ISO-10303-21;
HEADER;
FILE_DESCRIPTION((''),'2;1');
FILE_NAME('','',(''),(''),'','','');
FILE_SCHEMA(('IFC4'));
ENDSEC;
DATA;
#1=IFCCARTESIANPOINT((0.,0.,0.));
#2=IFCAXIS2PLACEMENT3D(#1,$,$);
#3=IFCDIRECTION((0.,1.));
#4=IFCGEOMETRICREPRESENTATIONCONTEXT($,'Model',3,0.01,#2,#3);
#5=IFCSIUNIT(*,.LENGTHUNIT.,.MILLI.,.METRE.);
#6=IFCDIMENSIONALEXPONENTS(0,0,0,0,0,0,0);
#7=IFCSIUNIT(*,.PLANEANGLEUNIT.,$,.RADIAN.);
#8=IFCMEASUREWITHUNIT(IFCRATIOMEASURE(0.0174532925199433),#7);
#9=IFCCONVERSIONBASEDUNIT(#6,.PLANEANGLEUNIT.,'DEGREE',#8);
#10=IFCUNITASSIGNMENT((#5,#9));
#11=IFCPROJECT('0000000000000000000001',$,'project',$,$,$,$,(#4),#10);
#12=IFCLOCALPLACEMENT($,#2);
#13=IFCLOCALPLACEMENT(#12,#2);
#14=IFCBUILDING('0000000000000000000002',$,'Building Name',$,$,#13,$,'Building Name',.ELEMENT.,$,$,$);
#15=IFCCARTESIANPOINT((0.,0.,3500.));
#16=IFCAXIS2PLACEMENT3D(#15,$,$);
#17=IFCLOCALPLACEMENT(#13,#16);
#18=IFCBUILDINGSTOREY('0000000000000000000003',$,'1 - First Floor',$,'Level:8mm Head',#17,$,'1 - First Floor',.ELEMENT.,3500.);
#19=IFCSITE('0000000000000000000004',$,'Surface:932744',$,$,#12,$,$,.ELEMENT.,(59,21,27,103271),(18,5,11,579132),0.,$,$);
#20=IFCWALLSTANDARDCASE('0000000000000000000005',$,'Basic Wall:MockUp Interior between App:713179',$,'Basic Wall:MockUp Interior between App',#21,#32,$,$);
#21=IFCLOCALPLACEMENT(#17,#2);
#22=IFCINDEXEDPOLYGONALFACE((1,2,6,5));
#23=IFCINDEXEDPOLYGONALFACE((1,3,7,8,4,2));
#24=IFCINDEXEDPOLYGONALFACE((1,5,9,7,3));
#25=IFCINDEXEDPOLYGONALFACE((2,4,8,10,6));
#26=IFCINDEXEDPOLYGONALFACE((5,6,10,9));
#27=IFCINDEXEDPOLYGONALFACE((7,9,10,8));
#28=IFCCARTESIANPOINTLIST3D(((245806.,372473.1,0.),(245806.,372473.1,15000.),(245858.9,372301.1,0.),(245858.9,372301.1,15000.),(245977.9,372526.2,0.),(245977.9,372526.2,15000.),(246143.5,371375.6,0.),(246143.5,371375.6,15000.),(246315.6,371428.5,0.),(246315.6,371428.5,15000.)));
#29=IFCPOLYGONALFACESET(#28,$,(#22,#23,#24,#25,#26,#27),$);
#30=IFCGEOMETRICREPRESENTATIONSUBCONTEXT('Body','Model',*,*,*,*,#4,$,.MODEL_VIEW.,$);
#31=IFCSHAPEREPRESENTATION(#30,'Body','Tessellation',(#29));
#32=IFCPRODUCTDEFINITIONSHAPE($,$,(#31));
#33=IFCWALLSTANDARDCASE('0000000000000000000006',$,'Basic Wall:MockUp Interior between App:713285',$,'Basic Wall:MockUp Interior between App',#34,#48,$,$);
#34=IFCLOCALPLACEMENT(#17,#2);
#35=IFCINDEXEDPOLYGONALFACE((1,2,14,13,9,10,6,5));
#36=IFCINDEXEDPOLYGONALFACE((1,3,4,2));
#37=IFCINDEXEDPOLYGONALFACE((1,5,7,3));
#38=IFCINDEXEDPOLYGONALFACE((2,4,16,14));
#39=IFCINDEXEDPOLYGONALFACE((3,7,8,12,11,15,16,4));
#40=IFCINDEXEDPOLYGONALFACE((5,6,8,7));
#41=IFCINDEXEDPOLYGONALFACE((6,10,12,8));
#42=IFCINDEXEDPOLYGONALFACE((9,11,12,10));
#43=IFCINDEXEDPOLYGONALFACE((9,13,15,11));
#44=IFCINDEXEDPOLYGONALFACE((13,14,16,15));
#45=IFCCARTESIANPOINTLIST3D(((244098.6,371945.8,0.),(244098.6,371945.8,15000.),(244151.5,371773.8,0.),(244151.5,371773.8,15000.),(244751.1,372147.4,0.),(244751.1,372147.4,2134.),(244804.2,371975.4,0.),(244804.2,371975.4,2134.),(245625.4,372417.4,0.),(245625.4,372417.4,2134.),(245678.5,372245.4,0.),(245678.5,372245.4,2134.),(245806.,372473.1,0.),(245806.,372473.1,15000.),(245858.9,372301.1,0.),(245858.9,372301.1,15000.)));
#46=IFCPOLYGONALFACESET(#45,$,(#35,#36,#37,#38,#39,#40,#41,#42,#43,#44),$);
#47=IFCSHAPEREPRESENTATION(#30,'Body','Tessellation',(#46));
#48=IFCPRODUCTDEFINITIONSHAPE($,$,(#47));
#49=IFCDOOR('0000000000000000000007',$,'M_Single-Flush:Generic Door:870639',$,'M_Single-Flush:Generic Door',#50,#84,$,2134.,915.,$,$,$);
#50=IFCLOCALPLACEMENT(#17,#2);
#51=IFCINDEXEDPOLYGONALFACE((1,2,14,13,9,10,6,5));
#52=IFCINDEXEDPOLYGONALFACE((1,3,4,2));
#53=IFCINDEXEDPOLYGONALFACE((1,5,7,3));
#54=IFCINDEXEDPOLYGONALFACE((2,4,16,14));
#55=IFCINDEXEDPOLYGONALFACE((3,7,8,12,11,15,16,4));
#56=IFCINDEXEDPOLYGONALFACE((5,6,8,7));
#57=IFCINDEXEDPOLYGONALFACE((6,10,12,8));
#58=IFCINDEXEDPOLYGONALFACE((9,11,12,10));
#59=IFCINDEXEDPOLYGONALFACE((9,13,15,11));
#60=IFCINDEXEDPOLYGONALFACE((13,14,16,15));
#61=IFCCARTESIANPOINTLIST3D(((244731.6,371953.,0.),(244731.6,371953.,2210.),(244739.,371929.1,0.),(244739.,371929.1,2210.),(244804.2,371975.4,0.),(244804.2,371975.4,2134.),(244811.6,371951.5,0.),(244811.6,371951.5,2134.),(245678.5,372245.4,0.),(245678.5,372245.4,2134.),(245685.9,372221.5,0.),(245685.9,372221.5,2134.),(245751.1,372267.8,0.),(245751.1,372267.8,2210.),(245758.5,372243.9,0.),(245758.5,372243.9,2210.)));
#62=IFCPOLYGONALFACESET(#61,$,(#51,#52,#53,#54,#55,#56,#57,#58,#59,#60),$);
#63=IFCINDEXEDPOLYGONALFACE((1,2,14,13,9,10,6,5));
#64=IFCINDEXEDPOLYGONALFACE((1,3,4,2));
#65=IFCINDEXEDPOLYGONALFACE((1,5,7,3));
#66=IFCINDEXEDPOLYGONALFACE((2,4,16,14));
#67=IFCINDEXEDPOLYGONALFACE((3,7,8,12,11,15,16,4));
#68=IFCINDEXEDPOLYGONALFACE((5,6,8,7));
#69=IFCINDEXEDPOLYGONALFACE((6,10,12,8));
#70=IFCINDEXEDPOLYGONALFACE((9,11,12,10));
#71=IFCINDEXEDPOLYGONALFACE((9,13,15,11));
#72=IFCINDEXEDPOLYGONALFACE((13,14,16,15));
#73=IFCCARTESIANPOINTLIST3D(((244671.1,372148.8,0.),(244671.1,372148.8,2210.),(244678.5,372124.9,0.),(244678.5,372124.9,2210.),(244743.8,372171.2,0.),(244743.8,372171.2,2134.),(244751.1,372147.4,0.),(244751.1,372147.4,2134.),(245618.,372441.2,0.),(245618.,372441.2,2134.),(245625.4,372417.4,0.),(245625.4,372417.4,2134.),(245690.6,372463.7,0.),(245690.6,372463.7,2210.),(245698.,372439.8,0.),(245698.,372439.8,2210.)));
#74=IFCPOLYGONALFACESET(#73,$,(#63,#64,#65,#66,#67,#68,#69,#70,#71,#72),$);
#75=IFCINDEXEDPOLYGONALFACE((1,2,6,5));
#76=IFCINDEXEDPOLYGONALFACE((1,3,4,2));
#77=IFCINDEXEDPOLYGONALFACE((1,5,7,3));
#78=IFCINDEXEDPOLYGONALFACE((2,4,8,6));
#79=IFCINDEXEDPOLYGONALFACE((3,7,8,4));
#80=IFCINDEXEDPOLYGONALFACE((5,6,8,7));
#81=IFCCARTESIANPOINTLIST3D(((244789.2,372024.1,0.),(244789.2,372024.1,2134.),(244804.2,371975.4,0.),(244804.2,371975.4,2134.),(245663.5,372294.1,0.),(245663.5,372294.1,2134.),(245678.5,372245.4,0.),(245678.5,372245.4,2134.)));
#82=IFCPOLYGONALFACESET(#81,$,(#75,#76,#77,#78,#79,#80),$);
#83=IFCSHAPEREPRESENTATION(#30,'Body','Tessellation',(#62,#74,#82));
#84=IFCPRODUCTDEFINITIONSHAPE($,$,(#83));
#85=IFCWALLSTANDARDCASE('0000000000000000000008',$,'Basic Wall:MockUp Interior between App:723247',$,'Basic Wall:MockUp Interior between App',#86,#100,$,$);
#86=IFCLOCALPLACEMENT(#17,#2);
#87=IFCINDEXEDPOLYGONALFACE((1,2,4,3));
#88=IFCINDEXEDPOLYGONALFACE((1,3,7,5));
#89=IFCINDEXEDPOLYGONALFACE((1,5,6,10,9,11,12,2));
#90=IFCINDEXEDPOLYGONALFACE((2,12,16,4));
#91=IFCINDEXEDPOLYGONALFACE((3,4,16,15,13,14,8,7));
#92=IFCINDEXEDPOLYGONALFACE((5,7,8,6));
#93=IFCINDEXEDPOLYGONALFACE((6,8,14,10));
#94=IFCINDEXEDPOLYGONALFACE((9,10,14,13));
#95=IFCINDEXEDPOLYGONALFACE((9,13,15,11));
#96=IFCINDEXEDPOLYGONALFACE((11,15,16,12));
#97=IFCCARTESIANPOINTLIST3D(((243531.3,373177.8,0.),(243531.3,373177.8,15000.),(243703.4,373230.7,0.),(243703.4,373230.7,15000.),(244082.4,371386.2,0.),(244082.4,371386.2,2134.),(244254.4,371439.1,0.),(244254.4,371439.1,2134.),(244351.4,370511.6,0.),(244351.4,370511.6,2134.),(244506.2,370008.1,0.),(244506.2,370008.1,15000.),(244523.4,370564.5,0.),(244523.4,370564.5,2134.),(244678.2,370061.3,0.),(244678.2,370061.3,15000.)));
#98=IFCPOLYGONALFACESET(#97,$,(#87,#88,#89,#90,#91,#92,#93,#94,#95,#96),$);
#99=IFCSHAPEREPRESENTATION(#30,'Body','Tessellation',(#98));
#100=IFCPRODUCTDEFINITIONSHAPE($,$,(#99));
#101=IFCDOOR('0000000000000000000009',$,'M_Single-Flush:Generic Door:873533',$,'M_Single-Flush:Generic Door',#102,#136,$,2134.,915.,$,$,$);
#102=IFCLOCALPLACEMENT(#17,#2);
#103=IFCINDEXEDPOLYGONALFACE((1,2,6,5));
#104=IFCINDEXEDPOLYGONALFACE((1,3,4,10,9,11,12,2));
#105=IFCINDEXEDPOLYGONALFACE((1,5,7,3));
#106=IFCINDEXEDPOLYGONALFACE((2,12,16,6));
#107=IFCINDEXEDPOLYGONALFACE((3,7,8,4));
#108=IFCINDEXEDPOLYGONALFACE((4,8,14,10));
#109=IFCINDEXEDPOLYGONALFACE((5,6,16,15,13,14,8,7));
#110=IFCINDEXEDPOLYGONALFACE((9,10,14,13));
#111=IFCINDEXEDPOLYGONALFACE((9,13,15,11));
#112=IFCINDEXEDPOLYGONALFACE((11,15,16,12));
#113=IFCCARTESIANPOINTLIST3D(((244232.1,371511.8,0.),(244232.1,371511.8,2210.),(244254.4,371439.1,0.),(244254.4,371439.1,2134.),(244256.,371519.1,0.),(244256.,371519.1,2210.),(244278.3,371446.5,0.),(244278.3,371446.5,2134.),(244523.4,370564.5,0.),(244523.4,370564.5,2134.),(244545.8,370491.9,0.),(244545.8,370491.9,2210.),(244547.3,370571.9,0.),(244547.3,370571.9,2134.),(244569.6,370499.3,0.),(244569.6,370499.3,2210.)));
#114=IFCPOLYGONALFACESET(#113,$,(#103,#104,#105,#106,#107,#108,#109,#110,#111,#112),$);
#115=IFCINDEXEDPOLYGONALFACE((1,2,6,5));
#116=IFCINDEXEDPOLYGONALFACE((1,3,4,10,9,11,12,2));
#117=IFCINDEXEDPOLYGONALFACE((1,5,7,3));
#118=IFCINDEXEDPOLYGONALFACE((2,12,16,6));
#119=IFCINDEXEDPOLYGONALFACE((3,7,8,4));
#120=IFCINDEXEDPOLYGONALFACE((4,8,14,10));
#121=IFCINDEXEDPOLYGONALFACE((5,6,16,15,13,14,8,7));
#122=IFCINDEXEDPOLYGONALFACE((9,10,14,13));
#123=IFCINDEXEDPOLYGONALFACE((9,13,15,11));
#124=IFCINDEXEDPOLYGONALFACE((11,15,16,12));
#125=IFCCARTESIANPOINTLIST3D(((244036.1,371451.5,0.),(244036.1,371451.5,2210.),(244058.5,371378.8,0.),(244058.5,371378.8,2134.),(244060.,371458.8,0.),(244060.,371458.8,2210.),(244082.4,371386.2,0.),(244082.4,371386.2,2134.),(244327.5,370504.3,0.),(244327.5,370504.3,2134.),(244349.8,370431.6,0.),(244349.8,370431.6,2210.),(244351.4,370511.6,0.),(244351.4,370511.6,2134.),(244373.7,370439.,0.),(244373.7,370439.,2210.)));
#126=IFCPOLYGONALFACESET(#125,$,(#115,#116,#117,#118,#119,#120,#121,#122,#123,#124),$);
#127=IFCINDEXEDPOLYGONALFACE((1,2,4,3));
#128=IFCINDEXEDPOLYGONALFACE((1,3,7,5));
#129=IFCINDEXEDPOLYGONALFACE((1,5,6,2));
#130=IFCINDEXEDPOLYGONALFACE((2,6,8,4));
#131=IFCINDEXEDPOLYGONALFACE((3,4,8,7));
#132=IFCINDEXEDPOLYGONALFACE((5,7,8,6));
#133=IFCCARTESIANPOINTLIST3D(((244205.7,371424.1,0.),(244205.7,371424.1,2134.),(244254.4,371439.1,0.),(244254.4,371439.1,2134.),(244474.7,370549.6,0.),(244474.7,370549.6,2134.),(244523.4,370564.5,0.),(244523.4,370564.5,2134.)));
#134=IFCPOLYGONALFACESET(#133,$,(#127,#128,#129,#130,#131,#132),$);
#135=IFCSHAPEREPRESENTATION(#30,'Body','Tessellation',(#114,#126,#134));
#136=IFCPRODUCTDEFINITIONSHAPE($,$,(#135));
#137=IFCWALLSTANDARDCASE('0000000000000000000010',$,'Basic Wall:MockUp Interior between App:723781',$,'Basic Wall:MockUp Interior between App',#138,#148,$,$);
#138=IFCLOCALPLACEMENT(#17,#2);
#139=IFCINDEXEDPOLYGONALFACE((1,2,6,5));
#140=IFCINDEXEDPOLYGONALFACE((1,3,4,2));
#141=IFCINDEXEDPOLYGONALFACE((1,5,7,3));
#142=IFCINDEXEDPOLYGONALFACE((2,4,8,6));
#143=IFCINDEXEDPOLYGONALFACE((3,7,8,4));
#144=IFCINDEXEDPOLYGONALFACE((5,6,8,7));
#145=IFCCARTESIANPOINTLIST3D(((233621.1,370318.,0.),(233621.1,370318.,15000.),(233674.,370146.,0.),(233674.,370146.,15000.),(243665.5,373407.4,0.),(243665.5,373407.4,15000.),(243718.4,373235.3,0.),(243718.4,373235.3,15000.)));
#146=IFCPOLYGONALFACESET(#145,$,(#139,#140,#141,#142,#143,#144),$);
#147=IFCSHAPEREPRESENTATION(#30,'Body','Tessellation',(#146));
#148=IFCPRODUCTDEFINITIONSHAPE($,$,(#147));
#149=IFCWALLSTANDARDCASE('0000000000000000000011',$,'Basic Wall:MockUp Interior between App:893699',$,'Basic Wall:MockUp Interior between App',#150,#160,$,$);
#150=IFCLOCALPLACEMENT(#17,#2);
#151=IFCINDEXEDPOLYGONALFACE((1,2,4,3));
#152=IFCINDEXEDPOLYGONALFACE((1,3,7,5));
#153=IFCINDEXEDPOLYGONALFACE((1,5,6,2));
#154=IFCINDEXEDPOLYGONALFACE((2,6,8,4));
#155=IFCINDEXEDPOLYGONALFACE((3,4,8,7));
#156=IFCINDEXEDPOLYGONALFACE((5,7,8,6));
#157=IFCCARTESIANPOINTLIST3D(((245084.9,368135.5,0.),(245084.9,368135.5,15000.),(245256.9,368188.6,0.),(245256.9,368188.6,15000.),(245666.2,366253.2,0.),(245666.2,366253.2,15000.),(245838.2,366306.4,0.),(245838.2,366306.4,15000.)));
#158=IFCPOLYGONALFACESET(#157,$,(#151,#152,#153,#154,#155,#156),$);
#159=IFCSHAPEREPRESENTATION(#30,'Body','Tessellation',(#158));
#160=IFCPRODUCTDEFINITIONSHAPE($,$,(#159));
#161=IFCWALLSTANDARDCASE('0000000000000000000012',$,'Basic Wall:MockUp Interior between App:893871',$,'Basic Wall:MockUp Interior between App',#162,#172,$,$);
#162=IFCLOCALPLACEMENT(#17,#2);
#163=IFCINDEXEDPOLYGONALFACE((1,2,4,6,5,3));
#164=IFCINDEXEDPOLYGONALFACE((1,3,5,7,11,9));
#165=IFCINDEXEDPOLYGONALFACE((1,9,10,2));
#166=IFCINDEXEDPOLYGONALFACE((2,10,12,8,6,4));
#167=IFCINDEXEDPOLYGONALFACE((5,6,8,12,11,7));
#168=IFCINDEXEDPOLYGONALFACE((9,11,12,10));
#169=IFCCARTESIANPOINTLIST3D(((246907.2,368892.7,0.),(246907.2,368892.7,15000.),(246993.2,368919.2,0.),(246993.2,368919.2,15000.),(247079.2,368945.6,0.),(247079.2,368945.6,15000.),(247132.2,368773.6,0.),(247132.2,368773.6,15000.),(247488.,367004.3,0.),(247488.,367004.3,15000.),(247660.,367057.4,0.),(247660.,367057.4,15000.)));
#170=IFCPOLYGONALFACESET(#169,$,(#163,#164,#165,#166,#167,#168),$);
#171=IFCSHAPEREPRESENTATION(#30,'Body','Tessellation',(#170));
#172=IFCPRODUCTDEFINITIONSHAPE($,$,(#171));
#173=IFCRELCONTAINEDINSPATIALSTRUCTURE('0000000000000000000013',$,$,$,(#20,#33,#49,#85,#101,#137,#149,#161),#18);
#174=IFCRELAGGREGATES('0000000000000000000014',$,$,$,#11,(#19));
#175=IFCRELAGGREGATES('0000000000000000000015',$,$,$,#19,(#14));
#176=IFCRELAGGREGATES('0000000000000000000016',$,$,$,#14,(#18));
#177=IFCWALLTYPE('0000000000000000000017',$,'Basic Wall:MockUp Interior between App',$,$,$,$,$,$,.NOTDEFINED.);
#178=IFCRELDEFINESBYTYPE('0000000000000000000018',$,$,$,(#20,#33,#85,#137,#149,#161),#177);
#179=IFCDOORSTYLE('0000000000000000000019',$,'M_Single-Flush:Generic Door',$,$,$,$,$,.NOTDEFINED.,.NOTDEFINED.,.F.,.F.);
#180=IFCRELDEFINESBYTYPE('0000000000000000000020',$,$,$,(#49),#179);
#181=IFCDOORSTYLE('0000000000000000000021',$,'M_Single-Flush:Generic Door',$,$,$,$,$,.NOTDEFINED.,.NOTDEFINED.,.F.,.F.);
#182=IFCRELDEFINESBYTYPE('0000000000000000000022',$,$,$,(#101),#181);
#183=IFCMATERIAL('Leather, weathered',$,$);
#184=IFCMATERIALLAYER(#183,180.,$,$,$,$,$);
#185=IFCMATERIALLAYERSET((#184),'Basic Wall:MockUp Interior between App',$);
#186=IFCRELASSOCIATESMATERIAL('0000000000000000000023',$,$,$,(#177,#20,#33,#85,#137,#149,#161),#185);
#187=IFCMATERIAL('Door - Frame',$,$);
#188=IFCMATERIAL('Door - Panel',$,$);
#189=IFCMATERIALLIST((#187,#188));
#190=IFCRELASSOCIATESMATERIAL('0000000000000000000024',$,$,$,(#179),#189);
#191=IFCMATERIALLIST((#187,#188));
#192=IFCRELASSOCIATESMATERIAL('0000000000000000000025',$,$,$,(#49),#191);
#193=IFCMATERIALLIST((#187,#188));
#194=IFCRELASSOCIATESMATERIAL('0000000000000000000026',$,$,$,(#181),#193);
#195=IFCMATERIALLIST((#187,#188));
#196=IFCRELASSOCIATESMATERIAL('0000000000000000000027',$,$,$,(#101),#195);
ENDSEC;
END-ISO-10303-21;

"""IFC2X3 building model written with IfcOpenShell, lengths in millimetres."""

from ifc_helpers import new_model, entity, si_unit, converted_unit, direction, frame, frame_2d, origin, place, context, subcontext, project, spatial, polyline, rectangle, outline, extrude, source, transform, mapped, material, material_list, layer, layer_set, layer_usage, type_object, type_shapes, element, fill, save


model = new_model("IFC2X3")

# Units and contexts
model_context = context("Model", 3, precision=0.01, world=origin(), true_north=direction((0.0, 1.0)))
body_context = subcontext(model_context, "Body", "Model", "MODEL_VIEW")
ifc_project = project(units=[si_unit("LENGTHUNIT", "METRE", prefix="MILLI"), converted_unit("PLANEANGLEUNIT", "DEGREE", entity("IfcRatioMeasure", 0.0174532925199433), si_unit("PLANEANGLEUNIT", "RADIAN"), dimensions=[0, 0, 0, 0, 0, 0, 0])], contexts=[model_context])

# Site, building, storey
site_placement = place(None, origin())
site = spatial("IfcSite", under=ifc_project, at=site_placement, Name="Surface:932744", CompositionType="ELEMENT", RefLatitude=(59, 21, 27, 103271), RefLongitude=(18, 5, 11, 579132), RefElevation=0.0)
building_placement = place(site_placement, origin())
building = spatial("IfcBuilding", under=site, at=building_placement, Name="Building Name", LongName="Building Name", CompositionType="ELEMENT")
storey_placement = place(building_placement, frame((0.0, 0.0, 3500.0)))
storey = spatial("IfcBuildingStorey", under=building, at=storey_placement, Name="1 - First Floor", ObjectType="Level:8mm Head", LongName="1 - First Floor", CompositionType="ELEMENT", Elevation=3500.0)

# Wall
ifc_material_1 = material(Name="Leather, weathered")
ifc_layer_1 = layer(ifc_material_1, 180.0)
ifc_layer_set_1 = layer_set([ifc_layer_1], Name="Basic Wall:MockUp Interior between App")
ifc_layer_usage_1 = layer_usage(ifc_layer_set_1, "AXIS2", "NEGATIVE", 90.0)
wall_type_1 = type_object("IfcWallType", Name="Basic Wall:MockUp Interior between App", PredefinedType="NOTDEFINED", material=ifc_layer_set_1)
wall_1_placement = place(storey_placement, frame((246229.5, 371402.1, 0.0), z_axis=(0.0, 0.0, 1.0), x_axis=(-0.29398, 0.955811, 0.0)))
element("IfcWallStandardCase", 1, at=wall_1_placement, inside=storey, type_object=wall_type_1, material=ifc_layer_usage_1, Name="Basic Wall:MockUp Interior between App:713179", ObjectType="Basic Wall:MockUp Interior between App", context=body_context, shape_type="SweptSolid", body=[
    extrude(outline(polyline([(1148.5, -90.0), (1148.3, 90.0), (968.3, 90.0), (0.0, 90.0), (0.0, -90.0), (1148.5, -90.0)])), origin(), (0.0, 0.0, 1.0), 15000.0),
])

# Walls, openings, doors
ifc_layer_usage_2 = layer_usage(ifc_layer_set_1, "AXIS2", "NEGATIVE", 90.0)
wall_2_placement = place(storey_placement, frame((245832.5, 372387.1, 0.0), z_axis=(0.0, 0.0, 1.0), x_axis=(-0.955473, -0.29508, 0.0)))
wall_2 = element("IfcWallStandardCase", 2, at=wall_2_placement, inside=storey, type_object=wall_type_1, material=ifc_layer_usage_2, Name="Basic Wall:MockUp Interior between App:713285", ObjectType="Basic Wall:MockUp Interior between App", context=body_context, shape_type="SweptSolid", body=[
    extrude(outline(polyline([(0.0, -90.0), (20.0, -90.0), (1787.0, -90.0), (1787.2, 90.0), (0.2, 90.0), (0.0, -90.0)])), origin(), (0.0, 0.0, 1.0), 15000.0),
])
opening_1_placement = place(wall_2_placement, frame((189.0, -90.0, 0.0)))
opening_1 = element("IfcOpeningElement", 3, at=opening_1_placement, cuts=wall_2, ObjectType="Opening", context=body_context, shape_type="SweptSolid", body=[
    extrude(rectangle(XDim=915.0, YDim=2134.0, at=frame_2d((1067.0, 457.5), x_axis=(0.0, -1.0))), frame((0.0, 0.0, 0.0), z_axis=(0.0, 1.0, 0.0), x_axis=(0.0, 0.0, 1.0)), (0.0, 0.0, 1.0), 180.0),
])
ifc_material_2 = material(Name="Door - Frame")
ifc_material_3 = material(Name="Door - Panel")
ifc_material_list_1 = material_list([ifc_material_2, ifc_material_3])
ifc_material_list_2 = material_list([ifc_material_2, ifc_material_3])
door_style_1 = type_object("IfcDoorStyle", Name="M_Single-Flush:Generic Door", ConstructionType="NOTDEFINED", OperationType="NOTDEFINED", ParameterTakesPrecedence=False, Sizeable=False, material=ifc_material_list_2)
shared_shape_1 = source(origin(), body_context, "Body", "SweptSolid", [
    extrude(outline(polyline([(-533.5, -1124.0), (533.5, -1124.0), (533.5, 1086.0), (457.5, 1086.0), (457.5, -1048.0), (-457.5, -1048.0), (-457.5, 1086.0), (-533.5, 1086.0), (-533.5, -1124.0)])), frame((457.5, 205.0, 1086.0), z_axis=(0.0, -1.0, 0.0), x_axis=(-1.0, 0.0, 0.0)), (0.0, 0.0, 1.0), 25.0),
    extrude(outline(polyline([(-1124.0, -533.5), (1086.0, -533.5), (1086.0, -457.5), (-1048.0, -457.5), (-1048.0, 457.5), (1086.0, 457.5), (1086.0, 533.5), (-1124.0, 533.5), (-1124.0, -533.5)])), frame((457.5, 0.0, 1086.0), z_axis=(0.0, -1.0, 0.0), x_axis=(0.0, 0.0, -1.0)), (0.0, 0.0, 1.0), 25.0),
    extrude(rectangle(XDim=915.0, YDim=51.0, at=frame_2d((0.0, 0.0), x_axis=(1.0, 0.0))), frame((457.5, 154.5, 0.0)), (0.0, 0.0, 1.0), 2134.0),
])
type_shapes(door_style_1, [shared_shape_1])
door_1_placement = place(opening_1_placement, origin())
door_1 = element("IfcDoor", 4, at=door_1_placement, inside=storey, type_object=door_style_1, material=ifc_material_list_1, Name="M_Single-Flush:Generic Door:870639", ObjectType="M_Single-Flush:Generic Door", OverallHeight=2134.0, OverallWidth=915.0, context=body_context, shape_type="MappedRepresentation", body=[
    mapped(shared_shape_1, transform((0.0, 0.0, 0.0), scale=1.0)),
])
fill(opening_1, door_1)
ifc_layer_usage_3 = layer_usage(ifc_layer_set_1, "AXIS2", "NEGATIVE", 90.0)
wall_3_placement = place(storey_placement, frame((243617.4, 373204.2, 0.0), z_axis=(0.0, 0.0, 1.0), x_axis=(0.29398, -0.955811, 0.0)))
wall_3 = element("IfcWallStandardCase", 5, at=wall_3_placement, inside=storey, type_object=wall_type_1, material=ifc_layer_usage_3, Name="Basic Wall:MockUp Interior between App:723247", ObjectType="Basic Wall:MockUp Interior between App", context=body_context, shape_type="SweptSolid", body=[
    extrude(outline(polyline([(0.0, -90.0), (3316.2, -90.0), (3316.0, 90.0), (1524.3, 90.0), (1344.3, 90.0), (0.0, 90.0), (0.0, -90.0)])), origin(), (0.0, 0.0, 1.0), 15000.0),
])
opening_2_placement = place(wall_3_placement, frame((1874.4, -90.0, 0.0)))
opening_2 = element("IfcOpeningElement", 6, at=opening_2_placement, cuts=wall_3, ObjectType="Opening", context=body_context, shape_type="SweptSolid", body=[
    extrude(rectangle(XDim=915.0, YDim=2134.0, at=frame_2d((1067.0, 457.5), x_axis=(0.0, 1.0))), frame((0.0, 0.0, 0.0), z_axis=(0.0, 1.0, 0.0), x_axis=(0.0, 0.0, 1.0)), (0.0, 0.0, 1.0), 180.0),
])
ifc_material_list_3 = material_list([ifc_material_2, ifc_material_3])
ifc_material_list_4 = material_list([ifc_material_2, ifc_material_3])
door_style_2 = type_object("IfcDoorStyle", Name="M_Single-Flush:Generic Door", ConstructionType="NOTDEFINED", OperationType="NOTDEFINED", ParameterTakesPrecedence=False, Sizeable=False, material=ifc_material_list_4)
shared_shape_2 = source(origin(), body_context, "Body", "SweptSolid", [
    extrude(outline(polyline([(-533.5, -1124.0), (533.5, -1124.0), (533.5, 1086.0), (457.5, 1086.0), (457.5, -1048.0), (-457.5, -1048.0), (-457.5, 1086.0), (-533.5, 1086.0), (-533.5, -1124.0)])), frame((457.5, 180.0, 1086.0), z_axis=(0.0, 1.0, 0.0), x_axis=(1.0, 0.0, 0.0)), (0.0, 0.0, 1.0), 25.0),
    extrude(outline(polyline([(-1124.0, -533.5), (1086.0, -533.5), (1086.0, -457.5), (-1048.0, -457.5), (-1048.0, 457.5), (1086.0, 457.5), (1086.0, 533.5), (-1124.0, 533.5), (-1124.0, -533.5)])), frame((457.5, -25.0, 1086.0), z_axis=(0.0, 1.0, 0.0), x_axis=(0.0, 0.0, -1.0)), (0.0, 0.0, 1.0), 25.0),
    extrude(rectangle(XDim=51.0, YDim=915.0, at=frame_2d((0.0, 0.0), x_axis=(1.0, 0.0))), frame((457.5, 154.5, 0.0), z_axis=(0.0, 0.0, 1.0), x_axis=(0.0, 1.0, 0.0)), (0.0, 0.0, 1.0), 2134.0),
])
type_shapes(door_style_2, [shared_shape_2])
door_2_placement = place(opening_2_placement, origin())
door_2 = element("IfcDoor", 7, at=door_2_placement, inside=storey, type_object=door_style_2, material=ifc_material_list_3, Name="M_Single-Flush:Generic Door:873533", ObjectType="M_Single-Flush:Generic Door", OverallHeight=2134.0, OverallWidth=915.0, context=body_context, shape_type="MappedRepresentation", body=[
    mapped(shared_shape_2, transform((0.0, 0.0, 0.0), scale=1.0)),
])
fill(opening_2, door_2)

# Walls
ifc_layer_usage_4 = layer_usage(ifc_layer_set_1, "AXIS2", "NEGATIVE", 90.0)
wall_4_placement = place(storey_placement, frame((243691.9, 373321.3, 0.0), z_axis=(0.0, 0.0, 1.0), x_axis=(-0.955811, -0.29398, 0.0)))
element("IfcWallStandardCase", 8, at=wall_4_placement, inside=storey, type_object=wall_type_1, material=ifc_layer_usage_4, Name="Basic Wall:MockUp Interior between App:723781", ObjectType="Basic Wall:MockUp Interior between App", context=body_context, shape_type="SweptSolid", body=[
    extrude(rectangle(XDim=10508.8, YDim=180.0, at=frame_2d((5254.4, 0.0), x_axis=(-1.0, 0.0))), origin(), (0.0, 0.0, 1.0), 15000.0),
])
ifc_layer_usage_5 = layer_usage(ifc_layer_set_1, "AXIS2", "NEGATIVE", 90.0)
wall_5_placement = place(storey_placement, frame((245170.9, 368162.1, 0.0), z_axis=(0.0, 0.0, 1.0), x_axis=(0.29508, -0.955473, 0.0)))
element("IfcWallStandardCase", 9, at=wall_5_placement, inside=storey, type_object=wall_type_1, material=ifc_layer_usage_5, Name="Basic Wall:MockUp Interior between App:893699", ObjectType="Basic Wall:MockUp Interior between App", context=body_context, shape_type="SweptSolid", body=[
    extrude(rectangle(XDim=1970.0, YDim=180.0, at=frame_2d((985.0, 0.0), x_axis=(-1.0, 0.0))), origin(), (0.0, 0.0, 1.0), 15000.0),
])
ifc_layer_usage_6 = layer_usage(ifc_layer_set_1, "AXIS2", "NEGATIVE", 90.0)
wall_6_placement = place(storey_placement, frame((247574.1, 367030.7, 0.0), z_axis=(0.0, 0.0, 1.0), x_axis=(-0.29398, 0.955811, 0.0)))
element("IfcWallStandardCase", 10, at=wall_6_placement, inside=storey, type_object=wall_type_1, material=ifc_layer_usage_6, Name="Basic Wall:MockUp Interior between App:893871", ObjectType="Basic Wall:MockUp Interior between App", context=body_context, shape_type="SweptSolid", body=[
    extrude(outline(polyline([(1975.7, -90.0), (1975.7, 0.0), (1975.7, 90.0), (0.0, 90.0), (0.2, -90.0), (1795.7, -90.0), (1975.7, -90.0)])), origin(), (0.0, 0.0, 1.0), 15000.0),
])

save(model, "model.ifc")
